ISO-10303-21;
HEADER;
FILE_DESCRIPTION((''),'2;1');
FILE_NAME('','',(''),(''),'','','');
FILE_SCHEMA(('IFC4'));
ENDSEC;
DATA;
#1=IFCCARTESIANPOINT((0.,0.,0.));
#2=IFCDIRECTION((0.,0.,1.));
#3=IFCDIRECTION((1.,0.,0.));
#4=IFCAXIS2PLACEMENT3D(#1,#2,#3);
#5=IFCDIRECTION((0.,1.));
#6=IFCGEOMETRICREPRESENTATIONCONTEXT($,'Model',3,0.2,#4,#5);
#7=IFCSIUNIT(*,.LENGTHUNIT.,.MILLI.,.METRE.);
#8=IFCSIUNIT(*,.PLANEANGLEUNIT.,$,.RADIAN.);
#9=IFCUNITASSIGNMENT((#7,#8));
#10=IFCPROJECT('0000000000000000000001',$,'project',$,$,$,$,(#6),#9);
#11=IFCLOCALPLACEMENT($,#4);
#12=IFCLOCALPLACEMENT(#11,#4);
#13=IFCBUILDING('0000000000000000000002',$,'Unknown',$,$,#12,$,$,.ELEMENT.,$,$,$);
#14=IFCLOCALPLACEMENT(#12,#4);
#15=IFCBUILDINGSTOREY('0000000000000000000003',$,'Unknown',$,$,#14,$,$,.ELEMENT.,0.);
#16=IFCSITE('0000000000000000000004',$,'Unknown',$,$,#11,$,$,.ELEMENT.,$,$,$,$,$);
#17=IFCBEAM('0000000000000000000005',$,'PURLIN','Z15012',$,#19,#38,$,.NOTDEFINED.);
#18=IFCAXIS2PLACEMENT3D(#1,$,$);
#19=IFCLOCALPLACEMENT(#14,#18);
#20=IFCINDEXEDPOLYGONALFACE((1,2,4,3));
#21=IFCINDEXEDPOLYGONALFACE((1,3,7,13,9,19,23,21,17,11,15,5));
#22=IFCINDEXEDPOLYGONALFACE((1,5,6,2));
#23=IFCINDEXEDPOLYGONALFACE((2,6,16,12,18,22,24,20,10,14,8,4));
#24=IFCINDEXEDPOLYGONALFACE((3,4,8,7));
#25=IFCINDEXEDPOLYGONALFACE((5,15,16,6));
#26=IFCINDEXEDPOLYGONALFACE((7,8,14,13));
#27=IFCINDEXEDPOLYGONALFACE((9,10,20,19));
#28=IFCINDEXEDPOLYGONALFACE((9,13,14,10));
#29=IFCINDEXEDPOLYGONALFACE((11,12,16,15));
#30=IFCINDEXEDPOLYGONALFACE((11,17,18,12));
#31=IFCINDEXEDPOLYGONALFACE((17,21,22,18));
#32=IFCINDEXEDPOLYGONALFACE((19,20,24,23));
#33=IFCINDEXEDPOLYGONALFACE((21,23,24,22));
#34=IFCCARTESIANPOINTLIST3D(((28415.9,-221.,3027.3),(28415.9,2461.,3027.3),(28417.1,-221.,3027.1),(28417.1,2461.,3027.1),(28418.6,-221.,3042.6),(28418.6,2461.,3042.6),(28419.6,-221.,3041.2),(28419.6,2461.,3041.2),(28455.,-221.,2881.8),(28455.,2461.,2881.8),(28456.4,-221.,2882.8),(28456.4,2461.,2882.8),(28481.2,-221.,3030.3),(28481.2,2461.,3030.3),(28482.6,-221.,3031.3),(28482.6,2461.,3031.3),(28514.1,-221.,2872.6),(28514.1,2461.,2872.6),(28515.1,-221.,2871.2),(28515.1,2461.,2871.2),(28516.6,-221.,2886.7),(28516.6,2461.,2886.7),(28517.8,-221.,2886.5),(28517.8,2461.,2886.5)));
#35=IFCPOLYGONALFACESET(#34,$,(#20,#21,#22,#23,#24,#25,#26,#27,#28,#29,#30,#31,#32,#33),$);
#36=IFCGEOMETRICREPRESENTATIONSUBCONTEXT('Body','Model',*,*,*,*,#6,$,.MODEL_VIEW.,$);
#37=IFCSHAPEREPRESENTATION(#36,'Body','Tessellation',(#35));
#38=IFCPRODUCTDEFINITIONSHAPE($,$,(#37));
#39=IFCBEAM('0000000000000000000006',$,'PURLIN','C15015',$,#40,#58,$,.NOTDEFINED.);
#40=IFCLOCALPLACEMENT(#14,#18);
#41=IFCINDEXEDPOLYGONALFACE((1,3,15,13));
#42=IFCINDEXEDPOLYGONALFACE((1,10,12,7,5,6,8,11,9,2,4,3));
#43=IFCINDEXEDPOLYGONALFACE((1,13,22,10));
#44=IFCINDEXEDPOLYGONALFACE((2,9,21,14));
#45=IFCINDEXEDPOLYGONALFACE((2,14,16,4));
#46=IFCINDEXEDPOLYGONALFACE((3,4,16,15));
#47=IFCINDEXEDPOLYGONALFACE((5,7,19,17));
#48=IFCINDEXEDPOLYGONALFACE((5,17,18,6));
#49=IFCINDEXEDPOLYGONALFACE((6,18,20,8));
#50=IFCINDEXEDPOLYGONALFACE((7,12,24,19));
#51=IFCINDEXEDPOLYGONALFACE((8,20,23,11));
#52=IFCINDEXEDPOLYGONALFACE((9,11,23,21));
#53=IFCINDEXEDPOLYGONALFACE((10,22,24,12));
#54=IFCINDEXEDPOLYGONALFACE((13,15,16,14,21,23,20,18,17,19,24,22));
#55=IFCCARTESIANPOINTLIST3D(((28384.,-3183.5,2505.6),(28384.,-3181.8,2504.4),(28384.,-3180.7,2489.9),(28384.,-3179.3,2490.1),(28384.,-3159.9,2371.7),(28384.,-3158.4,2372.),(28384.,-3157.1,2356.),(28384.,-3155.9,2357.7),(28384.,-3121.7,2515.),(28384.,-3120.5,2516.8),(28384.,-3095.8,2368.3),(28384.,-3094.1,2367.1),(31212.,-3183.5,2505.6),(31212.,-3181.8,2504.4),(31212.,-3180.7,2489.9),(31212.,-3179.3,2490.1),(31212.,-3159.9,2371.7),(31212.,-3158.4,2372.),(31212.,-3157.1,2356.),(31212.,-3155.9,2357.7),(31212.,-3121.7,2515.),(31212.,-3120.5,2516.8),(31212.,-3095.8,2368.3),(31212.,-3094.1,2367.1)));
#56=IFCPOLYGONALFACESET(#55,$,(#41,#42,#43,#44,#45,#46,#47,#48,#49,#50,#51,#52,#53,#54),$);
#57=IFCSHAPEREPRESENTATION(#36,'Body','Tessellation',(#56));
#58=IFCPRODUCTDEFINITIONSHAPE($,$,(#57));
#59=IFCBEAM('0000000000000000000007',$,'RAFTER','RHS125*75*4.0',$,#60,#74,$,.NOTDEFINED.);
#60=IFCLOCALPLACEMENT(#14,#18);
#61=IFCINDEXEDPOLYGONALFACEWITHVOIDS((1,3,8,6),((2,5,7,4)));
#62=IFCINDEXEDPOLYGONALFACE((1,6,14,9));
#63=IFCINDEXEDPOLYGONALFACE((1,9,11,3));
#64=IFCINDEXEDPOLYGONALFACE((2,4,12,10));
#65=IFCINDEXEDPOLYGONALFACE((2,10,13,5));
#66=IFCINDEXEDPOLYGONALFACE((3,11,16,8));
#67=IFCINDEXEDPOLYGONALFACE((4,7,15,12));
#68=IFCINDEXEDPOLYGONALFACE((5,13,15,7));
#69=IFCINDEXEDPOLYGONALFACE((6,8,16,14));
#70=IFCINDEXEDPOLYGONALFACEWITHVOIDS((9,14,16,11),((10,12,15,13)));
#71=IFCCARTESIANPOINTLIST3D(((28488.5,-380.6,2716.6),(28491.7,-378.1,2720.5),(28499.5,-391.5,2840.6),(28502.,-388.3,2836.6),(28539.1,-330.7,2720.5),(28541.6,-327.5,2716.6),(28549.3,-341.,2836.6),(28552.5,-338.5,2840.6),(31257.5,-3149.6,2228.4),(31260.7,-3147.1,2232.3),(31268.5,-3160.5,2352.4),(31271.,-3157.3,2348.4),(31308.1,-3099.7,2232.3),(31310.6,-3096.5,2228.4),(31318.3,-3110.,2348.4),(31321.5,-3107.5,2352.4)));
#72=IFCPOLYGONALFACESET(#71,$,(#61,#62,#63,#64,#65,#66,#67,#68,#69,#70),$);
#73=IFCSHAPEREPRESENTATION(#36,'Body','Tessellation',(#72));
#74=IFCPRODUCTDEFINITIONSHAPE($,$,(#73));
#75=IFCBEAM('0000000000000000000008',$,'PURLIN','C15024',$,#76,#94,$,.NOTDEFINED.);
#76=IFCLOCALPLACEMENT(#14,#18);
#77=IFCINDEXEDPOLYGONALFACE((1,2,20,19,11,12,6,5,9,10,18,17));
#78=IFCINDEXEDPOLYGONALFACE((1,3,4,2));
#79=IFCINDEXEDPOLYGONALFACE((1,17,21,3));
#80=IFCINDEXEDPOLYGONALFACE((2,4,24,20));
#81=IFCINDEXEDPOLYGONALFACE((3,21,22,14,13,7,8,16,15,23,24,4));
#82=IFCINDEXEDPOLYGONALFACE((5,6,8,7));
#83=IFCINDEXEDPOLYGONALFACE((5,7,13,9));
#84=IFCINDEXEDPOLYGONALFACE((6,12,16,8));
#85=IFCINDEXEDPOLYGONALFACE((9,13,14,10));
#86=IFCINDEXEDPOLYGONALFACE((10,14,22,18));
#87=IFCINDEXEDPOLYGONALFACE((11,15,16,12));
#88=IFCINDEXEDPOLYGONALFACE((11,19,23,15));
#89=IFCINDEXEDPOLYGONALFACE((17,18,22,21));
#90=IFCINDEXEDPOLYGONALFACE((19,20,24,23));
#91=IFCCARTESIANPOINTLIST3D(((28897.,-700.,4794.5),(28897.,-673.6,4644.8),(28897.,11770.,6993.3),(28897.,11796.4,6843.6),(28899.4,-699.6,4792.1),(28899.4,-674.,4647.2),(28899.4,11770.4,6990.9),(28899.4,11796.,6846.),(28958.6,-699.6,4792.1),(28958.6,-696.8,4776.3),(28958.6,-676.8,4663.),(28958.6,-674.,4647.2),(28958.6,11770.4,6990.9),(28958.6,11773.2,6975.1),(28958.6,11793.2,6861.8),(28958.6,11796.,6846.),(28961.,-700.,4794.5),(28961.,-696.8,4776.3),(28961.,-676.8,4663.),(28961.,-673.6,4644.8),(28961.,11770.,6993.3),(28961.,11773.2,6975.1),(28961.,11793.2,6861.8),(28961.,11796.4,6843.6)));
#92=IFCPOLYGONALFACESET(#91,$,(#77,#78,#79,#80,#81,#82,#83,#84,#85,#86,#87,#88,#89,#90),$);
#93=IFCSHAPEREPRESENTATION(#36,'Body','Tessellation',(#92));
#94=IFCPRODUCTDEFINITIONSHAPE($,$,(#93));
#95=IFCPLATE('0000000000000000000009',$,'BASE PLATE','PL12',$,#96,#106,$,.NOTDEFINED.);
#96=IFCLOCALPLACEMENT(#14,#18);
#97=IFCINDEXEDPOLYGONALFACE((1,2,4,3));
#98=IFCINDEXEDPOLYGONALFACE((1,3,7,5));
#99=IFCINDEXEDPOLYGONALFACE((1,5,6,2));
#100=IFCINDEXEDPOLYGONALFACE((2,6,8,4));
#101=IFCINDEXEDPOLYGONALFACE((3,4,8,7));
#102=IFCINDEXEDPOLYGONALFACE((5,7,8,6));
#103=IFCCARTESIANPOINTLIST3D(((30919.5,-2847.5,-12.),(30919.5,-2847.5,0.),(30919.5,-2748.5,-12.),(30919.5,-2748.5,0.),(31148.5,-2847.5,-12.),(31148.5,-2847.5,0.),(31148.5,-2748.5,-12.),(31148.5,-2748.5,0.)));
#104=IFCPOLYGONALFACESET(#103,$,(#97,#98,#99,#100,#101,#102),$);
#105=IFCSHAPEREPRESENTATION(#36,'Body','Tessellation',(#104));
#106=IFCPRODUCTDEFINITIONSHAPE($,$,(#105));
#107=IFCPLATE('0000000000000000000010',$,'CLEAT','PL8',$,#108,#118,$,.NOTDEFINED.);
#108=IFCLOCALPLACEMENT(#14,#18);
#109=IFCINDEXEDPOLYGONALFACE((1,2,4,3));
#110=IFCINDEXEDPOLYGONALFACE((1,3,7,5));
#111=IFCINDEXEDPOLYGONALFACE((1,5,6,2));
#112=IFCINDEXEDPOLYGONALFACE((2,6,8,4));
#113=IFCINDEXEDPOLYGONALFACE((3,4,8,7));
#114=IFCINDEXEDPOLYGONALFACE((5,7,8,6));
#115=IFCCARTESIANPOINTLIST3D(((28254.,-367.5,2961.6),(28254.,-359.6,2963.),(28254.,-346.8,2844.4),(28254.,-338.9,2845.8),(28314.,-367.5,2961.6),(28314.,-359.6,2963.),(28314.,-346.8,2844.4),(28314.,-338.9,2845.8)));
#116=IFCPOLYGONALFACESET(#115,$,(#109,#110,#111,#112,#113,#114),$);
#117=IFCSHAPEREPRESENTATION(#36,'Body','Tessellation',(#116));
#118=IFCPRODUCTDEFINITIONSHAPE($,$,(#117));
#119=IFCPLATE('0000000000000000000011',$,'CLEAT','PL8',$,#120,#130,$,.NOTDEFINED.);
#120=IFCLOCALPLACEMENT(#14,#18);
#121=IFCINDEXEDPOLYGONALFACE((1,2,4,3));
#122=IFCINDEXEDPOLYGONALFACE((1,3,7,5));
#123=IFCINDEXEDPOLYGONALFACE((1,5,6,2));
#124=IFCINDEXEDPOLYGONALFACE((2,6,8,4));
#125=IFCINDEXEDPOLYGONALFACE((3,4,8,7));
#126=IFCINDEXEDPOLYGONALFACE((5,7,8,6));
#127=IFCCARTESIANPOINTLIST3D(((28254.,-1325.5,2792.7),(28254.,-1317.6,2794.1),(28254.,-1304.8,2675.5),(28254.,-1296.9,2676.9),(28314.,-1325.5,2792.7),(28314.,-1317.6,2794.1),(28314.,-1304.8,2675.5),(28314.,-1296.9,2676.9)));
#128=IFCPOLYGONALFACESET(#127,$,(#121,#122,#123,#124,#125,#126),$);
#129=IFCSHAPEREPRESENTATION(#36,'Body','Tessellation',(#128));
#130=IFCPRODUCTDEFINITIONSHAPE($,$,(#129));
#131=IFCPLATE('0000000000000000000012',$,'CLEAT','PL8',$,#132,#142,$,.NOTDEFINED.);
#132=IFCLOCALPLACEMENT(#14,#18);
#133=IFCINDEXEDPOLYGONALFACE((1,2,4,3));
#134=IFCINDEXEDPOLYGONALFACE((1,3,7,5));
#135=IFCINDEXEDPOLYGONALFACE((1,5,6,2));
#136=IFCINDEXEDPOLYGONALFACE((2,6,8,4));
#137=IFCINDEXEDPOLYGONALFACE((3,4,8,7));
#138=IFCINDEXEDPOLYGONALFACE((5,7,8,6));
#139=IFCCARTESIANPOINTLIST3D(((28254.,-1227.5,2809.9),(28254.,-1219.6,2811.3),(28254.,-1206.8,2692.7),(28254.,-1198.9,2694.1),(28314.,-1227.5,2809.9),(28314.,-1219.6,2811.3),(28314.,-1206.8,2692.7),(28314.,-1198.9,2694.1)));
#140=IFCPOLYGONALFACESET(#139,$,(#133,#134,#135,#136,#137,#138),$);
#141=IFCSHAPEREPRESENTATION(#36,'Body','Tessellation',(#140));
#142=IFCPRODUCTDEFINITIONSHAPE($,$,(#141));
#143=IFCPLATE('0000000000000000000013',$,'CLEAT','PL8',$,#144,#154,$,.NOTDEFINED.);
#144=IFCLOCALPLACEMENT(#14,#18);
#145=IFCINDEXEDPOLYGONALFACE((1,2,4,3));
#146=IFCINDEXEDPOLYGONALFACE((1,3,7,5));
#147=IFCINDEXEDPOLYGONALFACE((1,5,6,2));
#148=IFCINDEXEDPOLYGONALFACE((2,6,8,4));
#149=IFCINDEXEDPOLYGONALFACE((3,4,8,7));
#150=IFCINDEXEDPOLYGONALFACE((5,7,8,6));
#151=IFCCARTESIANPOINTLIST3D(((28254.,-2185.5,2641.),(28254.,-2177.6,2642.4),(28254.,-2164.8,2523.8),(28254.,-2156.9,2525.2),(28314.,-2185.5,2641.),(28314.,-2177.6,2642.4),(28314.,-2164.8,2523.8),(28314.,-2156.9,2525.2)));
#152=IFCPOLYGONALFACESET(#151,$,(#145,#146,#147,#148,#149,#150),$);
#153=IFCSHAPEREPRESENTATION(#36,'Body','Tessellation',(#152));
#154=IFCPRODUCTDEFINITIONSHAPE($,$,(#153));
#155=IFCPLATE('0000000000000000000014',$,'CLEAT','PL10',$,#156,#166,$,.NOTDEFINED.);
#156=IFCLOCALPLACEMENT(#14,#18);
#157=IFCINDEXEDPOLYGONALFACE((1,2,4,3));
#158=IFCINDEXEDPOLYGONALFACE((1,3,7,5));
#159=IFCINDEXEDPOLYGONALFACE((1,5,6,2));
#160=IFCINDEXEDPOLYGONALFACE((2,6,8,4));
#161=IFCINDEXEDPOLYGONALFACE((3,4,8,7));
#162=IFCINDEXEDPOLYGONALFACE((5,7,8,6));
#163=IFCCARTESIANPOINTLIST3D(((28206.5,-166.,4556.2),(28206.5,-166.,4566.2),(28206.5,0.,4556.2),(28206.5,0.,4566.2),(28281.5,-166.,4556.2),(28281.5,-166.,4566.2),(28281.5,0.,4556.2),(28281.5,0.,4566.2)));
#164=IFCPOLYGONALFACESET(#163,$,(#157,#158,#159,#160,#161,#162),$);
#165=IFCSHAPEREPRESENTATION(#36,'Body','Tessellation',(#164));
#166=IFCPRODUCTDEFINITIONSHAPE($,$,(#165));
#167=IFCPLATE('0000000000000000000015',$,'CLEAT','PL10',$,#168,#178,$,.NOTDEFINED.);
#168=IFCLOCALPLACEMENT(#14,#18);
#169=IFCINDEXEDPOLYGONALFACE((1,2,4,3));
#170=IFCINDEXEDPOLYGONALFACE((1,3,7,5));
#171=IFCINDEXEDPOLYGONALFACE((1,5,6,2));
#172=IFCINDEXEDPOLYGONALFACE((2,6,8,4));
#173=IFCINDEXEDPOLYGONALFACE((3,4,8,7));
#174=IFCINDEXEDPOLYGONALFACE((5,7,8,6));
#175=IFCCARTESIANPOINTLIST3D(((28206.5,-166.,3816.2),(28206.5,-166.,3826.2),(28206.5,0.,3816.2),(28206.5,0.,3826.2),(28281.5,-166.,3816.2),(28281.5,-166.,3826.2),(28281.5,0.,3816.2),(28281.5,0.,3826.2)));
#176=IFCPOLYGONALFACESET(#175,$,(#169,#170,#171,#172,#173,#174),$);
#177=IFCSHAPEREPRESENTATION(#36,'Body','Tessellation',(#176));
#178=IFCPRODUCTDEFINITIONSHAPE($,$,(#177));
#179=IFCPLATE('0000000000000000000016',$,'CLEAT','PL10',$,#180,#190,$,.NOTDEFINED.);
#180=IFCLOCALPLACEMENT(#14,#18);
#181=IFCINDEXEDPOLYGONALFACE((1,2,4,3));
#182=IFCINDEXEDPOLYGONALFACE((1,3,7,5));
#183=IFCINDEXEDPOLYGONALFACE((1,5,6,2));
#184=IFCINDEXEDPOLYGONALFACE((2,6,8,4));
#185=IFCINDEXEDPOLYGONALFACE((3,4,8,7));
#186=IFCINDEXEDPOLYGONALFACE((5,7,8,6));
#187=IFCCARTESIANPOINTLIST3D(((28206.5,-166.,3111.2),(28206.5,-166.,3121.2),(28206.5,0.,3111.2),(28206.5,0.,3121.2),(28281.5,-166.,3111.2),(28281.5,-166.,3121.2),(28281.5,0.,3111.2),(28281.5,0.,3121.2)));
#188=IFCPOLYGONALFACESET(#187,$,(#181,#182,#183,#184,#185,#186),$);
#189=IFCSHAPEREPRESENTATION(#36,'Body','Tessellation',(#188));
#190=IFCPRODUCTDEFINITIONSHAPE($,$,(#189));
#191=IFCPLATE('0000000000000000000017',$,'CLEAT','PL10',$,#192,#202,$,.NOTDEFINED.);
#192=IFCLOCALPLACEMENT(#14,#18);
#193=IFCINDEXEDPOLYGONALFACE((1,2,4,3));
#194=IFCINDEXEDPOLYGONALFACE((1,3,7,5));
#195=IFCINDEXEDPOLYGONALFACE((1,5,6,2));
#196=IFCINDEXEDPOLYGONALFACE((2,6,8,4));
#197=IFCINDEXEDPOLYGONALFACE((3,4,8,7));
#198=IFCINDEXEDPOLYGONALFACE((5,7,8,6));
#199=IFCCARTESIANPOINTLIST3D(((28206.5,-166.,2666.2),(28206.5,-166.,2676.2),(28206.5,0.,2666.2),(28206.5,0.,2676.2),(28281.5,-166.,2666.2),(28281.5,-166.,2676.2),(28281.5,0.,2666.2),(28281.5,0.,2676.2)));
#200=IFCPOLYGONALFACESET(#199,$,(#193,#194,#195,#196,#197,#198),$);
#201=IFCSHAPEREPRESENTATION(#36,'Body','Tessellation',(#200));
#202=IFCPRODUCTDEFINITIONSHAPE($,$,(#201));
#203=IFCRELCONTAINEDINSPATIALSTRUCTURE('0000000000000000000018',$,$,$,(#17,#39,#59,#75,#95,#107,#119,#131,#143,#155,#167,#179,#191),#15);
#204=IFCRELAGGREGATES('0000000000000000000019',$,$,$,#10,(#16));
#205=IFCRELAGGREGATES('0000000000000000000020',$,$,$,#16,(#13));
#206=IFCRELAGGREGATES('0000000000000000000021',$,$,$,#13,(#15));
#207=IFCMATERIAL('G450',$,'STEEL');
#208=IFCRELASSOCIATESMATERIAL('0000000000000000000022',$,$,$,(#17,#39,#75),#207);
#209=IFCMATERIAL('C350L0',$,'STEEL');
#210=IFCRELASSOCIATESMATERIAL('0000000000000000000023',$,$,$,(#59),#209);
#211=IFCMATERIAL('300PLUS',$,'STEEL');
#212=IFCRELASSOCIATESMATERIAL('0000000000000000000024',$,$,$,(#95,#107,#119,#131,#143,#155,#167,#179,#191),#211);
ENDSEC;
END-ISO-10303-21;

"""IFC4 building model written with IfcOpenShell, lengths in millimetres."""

from ifc_helpers import new_model, si_unit, direction, frame, origin_with_axes, place, context, subcontext, project, spatial, line, indexed_curve, outline, extrude, material, element, save


model = new_model("IFC4")

# Units and contexts
model_context = context("Model", 3, precision=0.2, world=origin_with_axes(), true_north=direction((0.0, 1.0)))
body_context = subcontext(model_context, "Body", "Model", "MODEL_VIEW")
ifc_project = project(units=[si_unit("LENGTHUNIT", "METRE", prefix="MILLI"), si_unit("PLANEANGLEUNIT", "RADIAN")], contexts=[model_context])

# Site, building, storey
site_placement = place(None, origin_with_axes())
site = spatial("IfcSite", under=ifc_project, at=site_placement, Name="Unknown", CompositionType="ELEMENT")
building_placement = place(site_placement, origin_with_axes())
building = spatial("IfcBuilding", under=site, at=building_placement, Name="Unknown", CompositionType="ELEMENT")
storey_placement = place(building_placement, origin_with_axes())
storey = spatial("IfcBuildingStorey", under=building, at=storey_placement, Name="Unknown", CompositionType="ELEMENT", Elevation=0.0)

# Shared definitions
ifc_material_1 = material(Name="C350L0", Category="STEEL")

# Beams
ifc_material_2 = material(Name="G450", Category="STEEL")
beam_1_placement = place(storey_placement, frame((28468.8, -221.0, 2956.6), z_axis=(0.984808, 0.0, -0.173648), x_axis=(0.0, 1.0, 0.0)))
element("IfcBeam", 1, at=beam_1_placement, inside=storey, material=ifc_material_2, Name="PURLIN", Description="Z15012", PredefinedType="NOTDEFINED", context=body_context, shape_type="SolidModel", body=[
    extrude(outline(indexed_curve([(60.4, -76.0), (60.4, -60.5), (59.2, -60.5), (59.2, -74.8), (0.6, -74.8), (0.6, 76.0), (-64.4, 76.0), (-64.4, 60.5), (-63.2, 60.5), (-63.2, 74.8), (-0.6, 74.8), (-0.6, -76.0)], segments=[line(1, 2, 3, 4, 5, 6, 7, 8, 9, 10, 11, 12, 1)])), frame((0.0, 0.0, 0.0), z_axis=(-1.0, 0.0, 0.0), x_axis=(0.0, 0.0, 1.0)), (0.0, 0.0, -1.0), 2682.0),
])
beam_2_placement = place(storey_placement, frame((28384.0, -3138.8, 2436.4), z_axis=(0.0, -0.984808, -0.173648), x_axis=(1.0, 0.0, 0.0)))
element("IfcBeam", 2, at=beam_2_placement, inside=storey, material=ifc_material_2, Name="PURLIN", Description="C15015", PredefinedType="NOTDEFINED", context=body_context, shape_type="SolidModel", body=[
    extrude(outline(indexed_curve([(32.0, -76.0), (32.0, -60.0), (30.5, -60.0), (30.5, -74.5), (-30.5, -74.5), (-30.5, 74.5), (30.5, 74.5), (30.5, 60.0), (32.0, 60.0), (32.0, 76.0), (-32.0, 76.0), (-32.0, -76.0)], segments=[line(1, 2, 3, 4, 5, 6, 7, 8, 9, 10, 11, 12, 1)])), frame((0.0, 0.0, 0.0), z_axis=(-1.0, 0.0, 0.0), x_axis=(0.0, 0.0, 1.0)), (0.0, 0.0, -1.0), 2828.0),
])
beam_3_placement = place(storey_placement, frame((28520.5, -359.5, 2778.6), z_axis=(-0.707107, -0.707107, 0.0), x_axis=(0.701675, -0.701675, -0.123712)))
element("IfcBeam", 3, at=beam_3_placement, inside=storey, material=ifc_material_1, Name="RAFTER", Description="RHS125*75*4.0", PredefinedType="NOTDEFINED", context=body_context, shape_type="SolidModel", body=[
    extrude(outline(indexed_curve([(-37.5, -62.5), (37.5, -62.5), (37.5, 62.5), (-37.5, 62.5)], segments=[line(1, 2, 3, 4, 1)]), holes=[indexed_curve([(-33.5, -58.5), (-33.5, 58.5), (33.5, 58.5), (33.5, -58.5)], segments=[line(1, 2, 3, 4, 1)])]), frame((0.0, 0.0, 0.0), z_axis=(-1.0, 0.0, 0.0), x_axis=(0.0, 0.0, 1.0)), (0.0, 0.0, -1.0), 3946.3),
])
beam_4_placement = place(storey_placement, frame((28929.0, -686.8, 4719.7), z_axis=(1.0, 0.0, 0.0), x_axis=(0.0, 0.984808, 0.173648)))
element("IfcBeam", 4, at=beam_4_placement, inside=storey, material=ifc_material_2, Name="PURLIN", Description="C15024", PredefinedType="NOTDEFINED", context=body_context, shape_type="SolidModel", body=[
    extrude(outline(indexed_curve([(32.0, -76.0), (32.0, -57.5), (29.6, -57.5), (29.6, -73.6), (-29.6, -73.6), (-29.6, 73.6), (29.6, 73.6), (29.6, 57.5), (32.0, 57.5), (32.0, 76.0), (-32.0, 76.0), (-32.0, -76.0)], segments=[line(1, 2, 3, 4, 5, 6, 7, 8, 9, 10, 11, 12, 1)])), frame((0.0, 0.0, 0.0), z_axis=(-1.0, 0.0, 0.0), x_axis=(0.0, 0.0, 1.0)), (0.0, 0.0, -1.0), 12662.4),
])

# Plates
ifc_material_3 = material(Name="300PLUS", Category="STEEL")
plate_1_placement = place(storey_placement, frame((30919.5, -2847.5, -6.0), z_axis=(0.0, 0.0, 1.0), x_axis=(1.0, 0.0, 0.0)))
element("IfcPlate", 5, at=plate_1_placement, inside=storey, material=ifc_material_3, Name="BASE PLATE", Description="PL12", PredefinedType="NOTDEFINED", context=body_context, shape_type="SolidModel", body=[
    extrude(outline(indexed_curve([(0.0, 0.0), (229.0, 0.0), (229.0, 99.0), (0.0, 99.0)], segments=[line(1, 2, 3, 4, 1)])), frame((0.0, 0.0, 6.0), z_axis=(0.0, 0.0, 1.0), x_axis=(1.0, 0.0, 0.0)), (0.0, 0.0, -1.0), 12.0),
])
for number, where, z_axis, x_axis, name in (
    (6, (28314.0, -342.9, 2845.1), (0.0, 0.984758, 0.173929), (-1.0, 0.0, 0.0), "CLEAT"),
    (7, (28314.0, -1300.9, 2676.2), (0.0, 0.984758, 0.173929), (-1.0, 0.0, 0.0), "CLEAT"),
    (8, (28314.0, -1202.9, 2693.4), (0.0, 0.984758, 0.173929), (-1.0, 0.0, 0.0), "CLEAT"),
    (9, (28314.0, -2160.9, 2524.5), (0.0, 0.984758, 0.173929), (-1.0, 0.0, 0.0), "CLEAT"),
):
    element("IfcPlate", number, at=place(storey_placement, frame(where, z_axis=z_axis, x_axis=x_axis)), inside=storey, material=ifc_material_3, Name=name, Description="PL8", PredefinedType="NOTDEFINED", context=body_context, shape_type="SolidModel", body=[
        extrude(outline(indexed_curve([(0.0, 0.0), (60.0, 0.0), (60.0, 119.0), (0.0, 119.0)], segments=[line(1, 2, 3, 4, 1)])), frame((0.0, 0.0, 4.0), z_axis=(0.0, 0.0, 1.0), x_axis=(1.0, 0.0, 0.0)), (0.0, 0.0, -1.0), 8.0),
    ])
for number, where, z_axis, x_axis, name in (
    (10, (28281.5, 0.0, 4561.2), (0.0, 0.0, 1.0), (-1.0, 0.0, 0.0), "CLEAT"),
    (11, (28281.5, 0.0, 3821.2), (0.0, 0.0, 1.0), (-1.0, 0.0, 0.0), "CLEAT"),
    (12, (28281.5, 0.0, 3116.2), (0.0, 0.0, 1.0), (-1.0, 0.0, 0.0), "CLEAT"),
    (13, (28281.5, 0.0, 2671.2), (0.0, 0.0, 1.0), (-1.0, 0.0, 0.0), "CLEAT"),
):
    element("IfcPlate", number, at=place(storey_placement, frame(where, z_axis=z_axis, x_axis=x_axis)), inside=storey, material=ifc_material_3, Name=name, Description="PL10", PredefinedType="NOTDEFINED", context=body_context, shape_type="SolidModel", body=[
        extrude(outline(indexed_curve([(0.0, 0.0), (75.0, 0.0), (75.0, 166.0), (0.0, 166.0)], segments=[line(1, 2, 3, 4, 1)])), frame((0.0, 0.0, 5.0), z_axis=(0.0, 0.0, 1.0), x_axis=(1.0, 0.0, 0.0)), (0.0, 0.0, -1.0), 10.0),
    ])

save(model, "model.ifc")
